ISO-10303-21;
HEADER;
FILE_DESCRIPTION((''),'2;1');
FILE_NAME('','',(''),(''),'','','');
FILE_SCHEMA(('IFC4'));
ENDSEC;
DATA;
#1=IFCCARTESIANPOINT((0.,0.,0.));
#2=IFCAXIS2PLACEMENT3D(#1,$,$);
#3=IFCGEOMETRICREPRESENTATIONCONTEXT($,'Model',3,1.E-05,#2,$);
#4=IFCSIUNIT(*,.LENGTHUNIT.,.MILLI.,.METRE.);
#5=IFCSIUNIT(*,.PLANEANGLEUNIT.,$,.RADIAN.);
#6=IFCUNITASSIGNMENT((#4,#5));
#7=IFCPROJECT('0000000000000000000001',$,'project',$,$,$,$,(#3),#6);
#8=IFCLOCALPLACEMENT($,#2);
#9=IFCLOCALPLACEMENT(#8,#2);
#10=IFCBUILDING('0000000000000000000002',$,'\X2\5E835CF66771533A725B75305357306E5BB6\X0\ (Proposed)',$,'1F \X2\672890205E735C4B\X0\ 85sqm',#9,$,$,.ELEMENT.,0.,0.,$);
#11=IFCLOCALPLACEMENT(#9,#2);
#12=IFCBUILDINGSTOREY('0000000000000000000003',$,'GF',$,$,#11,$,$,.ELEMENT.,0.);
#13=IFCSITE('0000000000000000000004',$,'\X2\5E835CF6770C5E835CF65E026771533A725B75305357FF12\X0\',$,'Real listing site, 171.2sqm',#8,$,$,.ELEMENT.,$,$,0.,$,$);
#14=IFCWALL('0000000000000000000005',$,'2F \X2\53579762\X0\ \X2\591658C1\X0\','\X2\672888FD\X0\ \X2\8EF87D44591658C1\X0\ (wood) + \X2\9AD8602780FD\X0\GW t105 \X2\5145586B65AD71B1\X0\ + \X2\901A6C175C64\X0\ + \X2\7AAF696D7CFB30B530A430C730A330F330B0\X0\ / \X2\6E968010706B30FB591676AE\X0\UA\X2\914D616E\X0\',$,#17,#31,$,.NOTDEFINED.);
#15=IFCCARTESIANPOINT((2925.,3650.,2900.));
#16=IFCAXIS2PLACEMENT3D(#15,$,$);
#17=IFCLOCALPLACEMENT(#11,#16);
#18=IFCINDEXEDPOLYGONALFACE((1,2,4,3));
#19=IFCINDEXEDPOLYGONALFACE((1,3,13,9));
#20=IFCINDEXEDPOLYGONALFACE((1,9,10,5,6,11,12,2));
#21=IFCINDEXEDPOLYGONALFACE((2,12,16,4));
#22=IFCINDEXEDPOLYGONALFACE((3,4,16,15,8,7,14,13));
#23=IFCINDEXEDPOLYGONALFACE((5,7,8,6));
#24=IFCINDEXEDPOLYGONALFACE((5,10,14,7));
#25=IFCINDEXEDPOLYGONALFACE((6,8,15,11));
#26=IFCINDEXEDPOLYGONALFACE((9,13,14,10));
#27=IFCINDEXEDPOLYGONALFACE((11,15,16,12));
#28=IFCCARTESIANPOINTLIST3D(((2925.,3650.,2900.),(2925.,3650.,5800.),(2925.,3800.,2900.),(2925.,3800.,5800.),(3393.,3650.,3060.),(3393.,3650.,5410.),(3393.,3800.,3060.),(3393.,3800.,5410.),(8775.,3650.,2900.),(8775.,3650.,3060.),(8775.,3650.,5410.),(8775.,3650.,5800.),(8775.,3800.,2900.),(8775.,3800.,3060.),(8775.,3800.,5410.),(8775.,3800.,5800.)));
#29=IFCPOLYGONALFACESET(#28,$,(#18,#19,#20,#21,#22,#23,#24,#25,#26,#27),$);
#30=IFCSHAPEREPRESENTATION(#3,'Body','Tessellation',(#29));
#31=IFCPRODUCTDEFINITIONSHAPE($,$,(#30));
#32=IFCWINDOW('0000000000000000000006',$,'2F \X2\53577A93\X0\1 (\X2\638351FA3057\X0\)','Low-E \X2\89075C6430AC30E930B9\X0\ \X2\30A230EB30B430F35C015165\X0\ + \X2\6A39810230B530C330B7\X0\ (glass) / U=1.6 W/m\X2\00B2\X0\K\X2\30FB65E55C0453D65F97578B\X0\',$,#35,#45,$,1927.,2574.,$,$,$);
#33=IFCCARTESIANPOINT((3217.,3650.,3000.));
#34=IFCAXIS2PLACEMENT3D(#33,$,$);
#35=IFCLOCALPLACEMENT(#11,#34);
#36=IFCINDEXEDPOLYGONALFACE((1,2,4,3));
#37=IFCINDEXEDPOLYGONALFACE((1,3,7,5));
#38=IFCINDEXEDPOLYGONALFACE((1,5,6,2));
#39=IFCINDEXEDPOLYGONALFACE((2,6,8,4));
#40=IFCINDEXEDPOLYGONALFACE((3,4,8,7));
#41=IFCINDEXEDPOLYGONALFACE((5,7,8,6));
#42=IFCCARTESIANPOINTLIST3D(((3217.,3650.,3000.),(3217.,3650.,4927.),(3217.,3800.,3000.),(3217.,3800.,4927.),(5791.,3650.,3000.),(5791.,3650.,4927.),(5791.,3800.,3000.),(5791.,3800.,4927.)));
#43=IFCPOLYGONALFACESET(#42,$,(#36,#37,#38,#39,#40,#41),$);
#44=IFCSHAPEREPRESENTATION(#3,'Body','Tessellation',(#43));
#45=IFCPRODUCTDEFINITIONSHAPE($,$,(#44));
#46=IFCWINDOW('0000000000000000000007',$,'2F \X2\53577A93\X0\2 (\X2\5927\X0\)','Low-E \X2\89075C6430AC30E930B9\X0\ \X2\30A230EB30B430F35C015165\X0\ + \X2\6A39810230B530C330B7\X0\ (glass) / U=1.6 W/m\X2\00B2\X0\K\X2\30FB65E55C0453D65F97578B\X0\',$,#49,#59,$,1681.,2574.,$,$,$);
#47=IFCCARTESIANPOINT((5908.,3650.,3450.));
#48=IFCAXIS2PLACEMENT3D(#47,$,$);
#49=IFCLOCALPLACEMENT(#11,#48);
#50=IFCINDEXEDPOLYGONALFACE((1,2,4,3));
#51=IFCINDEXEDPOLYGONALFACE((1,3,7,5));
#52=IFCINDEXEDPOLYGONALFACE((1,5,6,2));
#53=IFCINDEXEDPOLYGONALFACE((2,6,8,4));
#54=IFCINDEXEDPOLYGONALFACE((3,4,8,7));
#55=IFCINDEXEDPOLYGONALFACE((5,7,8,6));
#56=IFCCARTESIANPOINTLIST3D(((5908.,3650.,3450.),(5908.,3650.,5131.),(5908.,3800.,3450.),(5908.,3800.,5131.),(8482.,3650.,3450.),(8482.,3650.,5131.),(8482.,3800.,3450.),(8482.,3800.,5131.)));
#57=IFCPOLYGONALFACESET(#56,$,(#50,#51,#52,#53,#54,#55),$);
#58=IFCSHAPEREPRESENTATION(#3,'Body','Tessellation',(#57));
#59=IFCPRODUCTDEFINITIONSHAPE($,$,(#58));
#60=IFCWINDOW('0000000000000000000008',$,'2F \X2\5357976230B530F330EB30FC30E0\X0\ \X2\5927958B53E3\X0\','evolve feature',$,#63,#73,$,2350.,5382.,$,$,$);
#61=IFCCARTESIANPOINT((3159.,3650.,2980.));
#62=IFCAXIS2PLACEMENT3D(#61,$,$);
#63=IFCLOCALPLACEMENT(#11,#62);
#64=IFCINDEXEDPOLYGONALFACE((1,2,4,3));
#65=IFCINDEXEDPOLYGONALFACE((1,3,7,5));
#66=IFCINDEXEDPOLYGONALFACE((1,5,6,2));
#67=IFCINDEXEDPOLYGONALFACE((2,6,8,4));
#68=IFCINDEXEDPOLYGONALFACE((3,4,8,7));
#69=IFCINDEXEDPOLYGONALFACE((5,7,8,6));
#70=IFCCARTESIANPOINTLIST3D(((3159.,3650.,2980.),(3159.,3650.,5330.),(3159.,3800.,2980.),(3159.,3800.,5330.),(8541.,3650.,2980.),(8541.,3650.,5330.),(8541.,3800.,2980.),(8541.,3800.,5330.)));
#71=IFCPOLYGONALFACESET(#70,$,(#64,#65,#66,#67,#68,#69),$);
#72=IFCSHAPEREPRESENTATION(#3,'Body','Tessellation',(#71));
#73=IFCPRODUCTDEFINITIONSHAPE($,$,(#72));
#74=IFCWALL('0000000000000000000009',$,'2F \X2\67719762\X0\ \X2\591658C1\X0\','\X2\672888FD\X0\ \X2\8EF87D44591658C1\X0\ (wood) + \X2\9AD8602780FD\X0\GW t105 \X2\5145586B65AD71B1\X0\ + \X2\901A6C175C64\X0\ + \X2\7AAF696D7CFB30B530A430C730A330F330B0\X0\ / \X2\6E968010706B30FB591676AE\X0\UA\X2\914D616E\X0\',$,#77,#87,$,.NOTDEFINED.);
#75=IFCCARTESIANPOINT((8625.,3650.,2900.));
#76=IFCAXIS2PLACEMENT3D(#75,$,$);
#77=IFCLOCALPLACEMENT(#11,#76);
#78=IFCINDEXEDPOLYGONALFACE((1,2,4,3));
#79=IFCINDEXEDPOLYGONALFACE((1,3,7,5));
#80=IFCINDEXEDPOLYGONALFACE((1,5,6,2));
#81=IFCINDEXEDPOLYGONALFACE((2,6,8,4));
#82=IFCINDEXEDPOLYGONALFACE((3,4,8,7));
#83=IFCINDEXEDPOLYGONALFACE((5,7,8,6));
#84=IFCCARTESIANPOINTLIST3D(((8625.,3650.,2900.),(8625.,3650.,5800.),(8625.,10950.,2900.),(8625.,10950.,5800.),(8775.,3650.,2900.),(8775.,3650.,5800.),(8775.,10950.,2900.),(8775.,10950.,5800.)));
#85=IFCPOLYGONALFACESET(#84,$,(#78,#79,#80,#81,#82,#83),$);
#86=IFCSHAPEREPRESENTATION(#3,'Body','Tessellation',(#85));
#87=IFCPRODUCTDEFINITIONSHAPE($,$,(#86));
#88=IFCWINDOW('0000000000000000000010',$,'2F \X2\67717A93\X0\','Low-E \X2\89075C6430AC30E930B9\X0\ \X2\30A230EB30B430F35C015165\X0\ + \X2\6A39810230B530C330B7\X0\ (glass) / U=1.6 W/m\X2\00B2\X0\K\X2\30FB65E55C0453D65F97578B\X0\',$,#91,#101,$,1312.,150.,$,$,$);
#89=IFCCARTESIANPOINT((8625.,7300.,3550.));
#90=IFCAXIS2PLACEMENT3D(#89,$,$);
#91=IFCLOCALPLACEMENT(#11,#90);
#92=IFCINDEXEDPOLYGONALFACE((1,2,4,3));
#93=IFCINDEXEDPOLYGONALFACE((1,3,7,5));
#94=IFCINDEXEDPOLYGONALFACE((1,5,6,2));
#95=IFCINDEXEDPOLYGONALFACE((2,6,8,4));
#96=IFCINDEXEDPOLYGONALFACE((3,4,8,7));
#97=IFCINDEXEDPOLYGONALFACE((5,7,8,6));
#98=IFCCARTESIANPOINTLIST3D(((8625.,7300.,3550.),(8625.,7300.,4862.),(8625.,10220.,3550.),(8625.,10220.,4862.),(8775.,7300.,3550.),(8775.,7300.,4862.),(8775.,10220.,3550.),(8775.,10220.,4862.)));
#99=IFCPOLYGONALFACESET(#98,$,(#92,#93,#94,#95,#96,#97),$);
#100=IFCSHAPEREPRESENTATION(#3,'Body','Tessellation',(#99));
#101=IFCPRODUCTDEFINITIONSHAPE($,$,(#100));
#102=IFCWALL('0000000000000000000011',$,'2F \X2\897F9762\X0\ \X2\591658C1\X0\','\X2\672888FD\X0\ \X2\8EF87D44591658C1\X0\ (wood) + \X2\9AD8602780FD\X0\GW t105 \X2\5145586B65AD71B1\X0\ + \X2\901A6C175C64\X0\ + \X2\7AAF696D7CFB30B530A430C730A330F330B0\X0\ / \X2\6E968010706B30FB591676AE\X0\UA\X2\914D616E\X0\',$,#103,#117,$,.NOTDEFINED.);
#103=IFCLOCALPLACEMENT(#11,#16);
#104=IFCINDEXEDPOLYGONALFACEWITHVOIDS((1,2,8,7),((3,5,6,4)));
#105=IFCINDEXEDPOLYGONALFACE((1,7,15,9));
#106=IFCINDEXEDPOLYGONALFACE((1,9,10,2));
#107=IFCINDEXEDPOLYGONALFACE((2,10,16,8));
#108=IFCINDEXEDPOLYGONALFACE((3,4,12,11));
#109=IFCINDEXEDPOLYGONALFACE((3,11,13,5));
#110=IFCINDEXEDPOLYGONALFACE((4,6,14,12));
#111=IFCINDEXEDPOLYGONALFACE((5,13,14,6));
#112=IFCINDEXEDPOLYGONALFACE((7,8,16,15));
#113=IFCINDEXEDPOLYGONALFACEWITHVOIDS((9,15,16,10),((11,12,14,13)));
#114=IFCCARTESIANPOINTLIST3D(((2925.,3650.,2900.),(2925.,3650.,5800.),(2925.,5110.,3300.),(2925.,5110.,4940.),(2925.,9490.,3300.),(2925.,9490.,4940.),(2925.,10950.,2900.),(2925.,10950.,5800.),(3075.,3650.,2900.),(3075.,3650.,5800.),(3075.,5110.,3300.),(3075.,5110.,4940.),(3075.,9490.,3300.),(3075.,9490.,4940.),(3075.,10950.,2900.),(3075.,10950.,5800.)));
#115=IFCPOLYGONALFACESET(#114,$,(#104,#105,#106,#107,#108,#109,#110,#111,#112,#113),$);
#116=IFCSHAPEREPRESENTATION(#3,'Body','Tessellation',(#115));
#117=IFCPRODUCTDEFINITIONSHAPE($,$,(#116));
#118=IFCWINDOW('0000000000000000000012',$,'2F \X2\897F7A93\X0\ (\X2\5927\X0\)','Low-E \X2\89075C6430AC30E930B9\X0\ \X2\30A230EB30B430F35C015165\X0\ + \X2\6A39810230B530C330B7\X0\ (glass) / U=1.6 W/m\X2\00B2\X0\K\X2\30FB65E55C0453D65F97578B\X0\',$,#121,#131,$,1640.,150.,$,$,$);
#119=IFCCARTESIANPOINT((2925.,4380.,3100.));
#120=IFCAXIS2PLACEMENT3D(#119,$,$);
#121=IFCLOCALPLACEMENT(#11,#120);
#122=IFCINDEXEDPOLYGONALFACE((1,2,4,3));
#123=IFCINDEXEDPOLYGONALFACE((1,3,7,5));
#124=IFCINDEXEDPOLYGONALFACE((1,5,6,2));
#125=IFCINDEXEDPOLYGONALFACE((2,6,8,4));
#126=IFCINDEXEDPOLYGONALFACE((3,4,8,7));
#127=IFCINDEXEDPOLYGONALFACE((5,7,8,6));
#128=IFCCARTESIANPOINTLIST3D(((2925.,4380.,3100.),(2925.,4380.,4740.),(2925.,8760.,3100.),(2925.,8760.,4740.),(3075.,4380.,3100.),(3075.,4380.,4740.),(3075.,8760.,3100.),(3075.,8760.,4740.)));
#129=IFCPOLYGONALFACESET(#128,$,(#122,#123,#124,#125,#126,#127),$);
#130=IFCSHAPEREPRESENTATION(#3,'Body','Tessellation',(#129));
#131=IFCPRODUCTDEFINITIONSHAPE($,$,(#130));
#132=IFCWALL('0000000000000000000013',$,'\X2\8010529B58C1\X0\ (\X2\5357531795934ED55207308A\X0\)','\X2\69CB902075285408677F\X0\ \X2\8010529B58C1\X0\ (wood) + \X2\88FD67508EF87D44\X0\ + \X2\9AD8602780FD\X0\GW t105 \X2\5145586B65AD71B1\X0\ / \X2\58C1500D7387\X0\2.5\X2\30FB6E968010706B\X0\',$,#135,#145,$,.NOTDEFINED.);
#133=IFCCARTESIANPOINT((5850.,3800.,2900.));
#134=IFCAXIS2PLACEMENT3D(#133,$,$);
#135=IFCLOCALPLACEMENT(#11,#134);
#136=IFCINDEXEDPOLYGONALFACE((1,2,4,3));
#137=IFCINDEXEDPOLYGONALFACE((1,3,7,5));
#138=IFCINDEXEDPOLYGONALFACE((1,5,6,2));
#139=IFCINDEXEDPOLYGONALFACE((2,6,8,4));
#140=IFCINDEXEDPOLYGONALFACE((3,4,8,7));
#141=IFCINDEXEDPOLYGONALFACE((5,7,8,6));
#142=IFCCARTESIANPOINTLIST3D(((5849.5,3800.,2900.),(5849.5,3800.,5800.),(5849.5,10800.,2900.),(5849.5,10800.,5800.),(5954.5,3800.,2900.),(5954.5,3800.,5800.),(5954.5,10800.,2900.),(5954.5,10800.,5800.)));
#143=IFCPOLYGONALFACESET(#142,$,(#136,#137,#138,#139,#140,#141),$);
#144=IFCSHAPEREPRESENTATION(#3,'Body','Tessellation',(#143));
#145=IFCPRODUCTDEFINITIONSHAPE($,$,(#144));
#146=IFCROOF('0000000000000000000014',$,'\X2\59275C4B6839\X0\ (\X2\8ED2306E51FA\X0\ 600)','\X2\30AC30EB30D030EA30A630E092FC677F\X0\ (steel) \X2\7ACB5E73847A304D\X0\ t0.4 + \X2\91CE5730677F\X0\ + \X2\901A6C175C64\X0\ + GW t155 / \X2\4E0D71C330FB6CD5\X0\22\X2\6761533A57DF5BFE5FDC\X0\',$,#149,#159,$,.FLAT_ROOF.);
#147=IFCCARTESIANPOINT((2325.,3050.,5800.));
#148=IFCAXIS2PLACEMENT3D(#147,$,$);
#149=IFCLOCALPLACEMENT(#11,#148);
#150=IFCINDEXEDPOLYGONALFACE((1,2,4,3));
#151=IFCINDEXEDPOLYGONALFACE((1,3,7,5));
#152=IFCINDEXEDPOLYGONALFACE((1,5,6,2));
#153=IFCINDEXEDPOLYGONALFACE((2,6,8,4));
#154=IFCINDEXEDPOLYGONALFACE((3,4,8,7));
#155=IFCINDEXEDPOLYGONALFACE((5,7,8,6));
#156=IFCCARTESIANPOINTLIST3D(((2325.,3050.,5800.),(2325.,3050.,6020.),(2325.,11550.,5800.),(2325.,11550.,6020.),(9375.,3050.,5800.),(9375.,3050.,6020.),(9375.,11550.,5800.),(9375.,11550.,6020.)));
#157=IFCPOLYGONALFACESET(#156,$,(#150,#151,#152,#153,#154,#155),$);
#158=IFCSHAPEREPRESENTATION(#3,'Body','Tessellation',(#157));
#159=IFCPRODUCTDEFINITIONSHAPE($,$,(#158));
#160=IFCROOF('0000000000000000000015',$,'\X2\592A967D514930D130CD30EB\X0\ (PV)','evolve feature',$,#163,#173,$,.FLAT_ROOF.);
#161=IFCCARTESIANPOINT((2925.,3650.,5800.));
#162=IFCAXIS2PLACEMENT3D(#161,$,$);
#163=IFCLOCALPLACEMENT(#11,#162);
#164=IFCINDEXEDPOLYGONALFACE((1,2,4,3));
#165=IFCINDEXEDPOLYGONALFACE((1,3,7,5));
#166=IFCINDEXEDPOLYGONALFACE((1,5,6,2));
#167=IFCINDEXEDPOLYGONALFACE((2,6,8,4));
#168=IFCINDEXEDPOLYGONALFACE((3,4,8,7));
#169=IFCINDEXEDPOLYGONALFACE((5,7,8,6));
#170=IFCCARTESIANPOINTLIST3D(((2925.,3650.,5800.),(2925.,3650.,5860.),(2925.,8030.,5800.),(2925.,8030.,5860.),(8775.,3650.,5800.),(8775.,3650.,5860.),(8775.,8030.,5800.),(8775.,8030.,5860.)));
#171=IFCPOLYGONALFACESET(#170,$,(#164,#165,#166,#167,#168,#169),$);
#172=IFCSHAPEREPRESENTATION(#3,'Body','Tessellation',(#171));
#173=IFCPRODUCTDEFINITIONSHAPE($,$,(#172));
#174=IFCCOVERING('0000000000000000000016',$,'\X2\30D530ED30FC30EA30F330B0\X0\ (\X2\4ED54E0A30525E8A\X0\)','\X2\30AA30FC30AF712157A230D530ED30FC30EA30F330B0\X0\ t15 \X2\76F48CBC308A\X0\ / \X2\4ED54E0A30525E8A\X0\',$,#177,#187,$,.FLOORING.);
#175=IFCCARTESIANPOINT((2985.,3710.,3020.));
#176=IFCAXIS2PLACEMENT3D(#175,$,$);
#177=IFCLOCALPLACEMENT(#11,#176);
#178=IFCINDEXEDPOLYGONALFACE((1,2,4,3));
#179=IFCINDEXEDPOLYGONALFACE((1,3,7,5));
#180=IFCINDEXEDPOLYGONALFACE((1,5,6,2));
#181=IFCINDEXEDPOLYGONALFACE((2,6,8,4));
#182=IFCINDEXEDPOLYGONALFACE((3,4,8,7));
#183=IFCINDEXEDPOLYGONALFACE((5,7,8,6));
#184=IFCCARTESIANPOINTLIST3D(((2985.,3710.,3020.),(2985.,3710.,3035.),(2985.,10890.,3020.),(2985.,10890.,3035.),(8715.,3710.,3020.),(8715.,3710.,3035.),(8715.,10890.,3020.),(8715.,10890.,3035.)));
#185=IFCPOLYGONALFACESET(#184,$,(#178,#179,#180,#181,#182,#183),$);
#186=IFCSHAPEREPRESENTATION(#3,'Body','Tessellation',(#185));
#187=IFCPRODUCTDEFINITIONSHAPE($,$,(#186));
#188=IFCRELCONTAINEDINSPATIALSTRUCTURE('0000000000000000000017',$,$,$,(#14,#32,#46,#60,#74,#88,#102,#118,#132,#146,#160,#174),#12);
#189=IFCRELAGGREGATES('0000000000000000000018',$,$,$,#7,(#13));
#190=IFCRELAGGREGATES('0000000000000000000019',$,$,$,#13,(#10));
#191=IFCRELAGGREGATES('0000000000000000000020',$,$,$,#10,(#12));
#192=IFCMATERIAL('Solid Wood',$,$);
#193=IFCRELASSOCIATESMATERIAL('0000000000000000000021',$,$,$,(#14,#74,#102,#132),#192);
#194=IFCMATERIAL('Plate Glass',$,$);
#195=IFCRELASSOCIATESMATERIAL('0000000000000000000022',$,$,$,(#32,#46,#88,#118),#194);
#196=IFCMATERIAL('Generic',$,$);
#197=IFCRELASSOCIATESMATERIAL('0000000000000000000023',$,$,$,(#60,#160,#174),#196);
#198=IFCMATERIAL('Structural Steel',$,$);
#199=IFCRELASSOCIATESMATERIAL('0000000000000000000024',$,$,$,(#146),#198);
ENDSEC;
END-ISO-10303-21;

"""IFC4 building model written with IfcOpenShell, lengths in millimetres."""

from ifc_helpers import new_model, si_unit, frame, frame_2d, origin, place, context, project, spatial, rectangle, extrude, material, element, fill, save


model = new_model("IFC4")

# Units and contexts
model_context = context("Model", 3, precision=1e-05, world=origin())
ifc_project = project(units=[si_unit("LENGTHUNIT", "METRE", prefix="MILLI"), si_unit("PLANEANGLEUNIT", "RADIAN")], contexts=[model_context])

# Site, building, storey
site_placement = place(None, origin())
site = spatial("IfcSite", under=ifc_project, at=site_placement, Name="広島県広島市東区牛田南２", ObjectType="Real listing site, 171.2sqm", CompositionType="ELEMENT", RefElevation=0.0)
building_placement = place(site_placement, origin())
building = spatial("IfcBuilding", under=site, at=building_placement, Name="広島東区牛田南の家 (Proposed)", ObjectType="1F 木造平屋 85sqm", CompositionType="ELEMENT", ElevationOfRefHeight=0.0, ElevationOfTerrain=0.0)
storey_placement = place(building_placement, origin())
storey = spatial("IfcBuildingStorey", under=building, at=storey_placement, Name="GF", CompositionType="ELEMENT", Elevation=0.0)

# Shared definitions
ifc_material_1 = material(Name="Solid Wood")

# Wall, openings, windows
wall_1_placement = place(storey_placement, frame((2925.0, 3650.0, 2900.0)))
wall_1 = element("IfcWall", 1, at=wall_1_placement, inside=storey, material=ifc_material_1, Name="2F 南面 外壁", Description="木製 軸組外壁 (wood) + 高性能GW t105 充填断熱 + 通気層 + 窯業系サイディング / 準耐火・外皮UA配慮", PredefinedType="NOTDEFINED", context=model_context, shape_type="SweptSolid", body=[
    extrude(rectangle(XDim=5850.0, YDim=150.0, at=frame_2d((2925.0, 75.0))), frame((2925.0, 3650.0, 2900.0)), (0.0, 0.0, 1.0), 2900.0),
])
opening_1_placement = place(storey_placement, frame((3217.0, 3650.0, 3000.0)))
opening_1 = element("IfcOpeningElement", 2, at=opening_1_placement, cuts=wall_1, PredefinedType="NOTDEFINED", context=model_context, shape_type="SweptSolid", body=[
    extrude(rectangle(XDim=2574.0, YDim=150.0, at=frame_2d((1287.0, 75.0))), frame((3217.0, 3650.0, 3000.0)), (0.0, 0.0, 1.0), 1927.0),
])
opening_2_placement = place(storey_placement, frame((5908.0, 3650.0, 3450.0)))
opening_2 = element("IfcOpeningElement", 3, at=opening_2_placement, cuts=wall_1, PredefinedType="NOTDEFINED", context=model_context, shape_type="SweptSolid", body=[
    extrude(rectangle(XDim=2574.0, YDim=150.0, at=frame_2d((1287.0, 75.0))), frame((5908.0, 3650.0, 3450.0)), (0.0, 0.0, 1.0), 1681.0),
])
opening_3_placement = place(storey_placement, frame((3159.0, 3650.0, 2980.0)))
opening_3 = element("IfcOpeningElement", 4, at=opening_3_placement, cuts=wall_1, PredefinedType="NOTDEFINED", context=model_context, shape_type="SweptSolid", body=[
    extrude(rectangle(XDim=5382.0, YDim=150.0, at=frame_2d((2691.0, 75.0))), frame((3159.0, 3650.0, 2980.0)), (0.0, 0.0, 1.0), 2350.0),
])
ifc_material_2 = material(Name="Plate Glass")
window_1_placement = place(storey_placement, frame((3217.0, 3650.0, 3000.0)))
window_1 = element("IfcWindow", 5, at=window_1_placement, inside=storey, material=ifc_material_2, Name="2F 南窓1 (掃出し)", Description="Low-E 複層ガラス アルゴン封入 + 樹脂サッシ (glass) / U=1.6 W/m²K・日射取得型", OverallHeight=1927.0, OverallWidth=2574.0, context=model_context, shape_type="SweptSolid", body=[
    extrude(rectangle(XDim=2574.0, YDim=150.0, at=frame_2d((1287.0, 75.0))), frame((3217.0, 3650.0, 3000.0)), (0.0, 0.0, 1.0), 1927.0),
])
fill(opening_1, window_1)
window_2_placement = place(storey_placement, frame((5908.0, 3650.0, 3450.0)))
window_2 = element("IfcWindow", 6, at=window_2_placement, inside=storey, material=ifc_material_2, Name="2F 南窓2 (大)", Description="Low-E 複層ガラス アルゴン封入 + 樹脂サッシ (glass) / U=1.6 W/m²K・日射取得型", OverallHeight=1681.0, OverallWidth=2574.0, context=model_context, shape_type="SweptSolid", body=[
    extrude(rectangle(XDim=2574.0, YDim=150.0, at=frame_2d((1287.0, 75.0))), frame((5908.0, 3650.0, 3450.0)), (0.0, 0.0, 1.0), 1681.0),
])
fill(opening_2, window_2)
ifc_material_3 = material(Name="Generic")
window_3_placement = place(storey_placement, frame((3159.0, 3650.0, 2980.0)))
window_3 = element("IfcWindow", 7, at=window_3_placement, inside=storey, material=ifc_material_3, Name="2F 南面サンルーム 大開口", Description="evolve feature", OverallHeight=2350.0, OverallWidth=5382.0, context=model_context, shape_type="SweptSolid", body=[
    extrude(rectangle(XDim=5382.0, YDim=150.0, at=frame_2d((2691.0, 75.0))), frame((3159.0, 3650.0, 2980.0)), (0.0, 0.0, 1.0), 2350.0),
])
fill(opening_3, window_3)

# Walls, openings, windows
wall_2_placement = place(storey_placement, frame((8625.0, 3650.0, 2900.0)))
wall_2 = element("IfcWall", 8, at=wall_2_placement, inside=storey, material=ifc_material_1, Name="2F 東面 外壁", Description="木製 軸組外壁 (wood) + 高性能GW t105 充填断熱 + 通気層 + 窯業系サイディング / 準耐火・外皮UA配慮", PredefinedType="NOTDEFINED", context=model_context, shape_type="SweptSolid", body=[
    extrude(rectangle(XDim=150.0, YDim=7300.0, at=frame_2d((75.0, 3650.0))), frame((8625.0, 3650.0, 2900.0)), (0.0, 0.0, 1.0), 2900.0),
])
opening_4_placement = place(storey_placement, frame((8625.0, 7300.0, 3550.0)))
opening_4 = element("IfcOpeningElement", 9, at=opening_4_placement, cuts=wall_2, PredefinedType="NOTDEFINED", context=model_context, shape_type="SweptSolid", body=[
    extrude(rectangle(XDim=150.0, YDim=2920.0, at=frame_2d((75.0, 1460.0))), frame((8625.0, 7300.0, 3550.0)), (0.0, 0.0, 1.0), 1312.0),
])
window_4_placement = place(storey_placement, frame((8625.0, 7300.0, 3550.0)))
window_4 = element("IfcWindow", 10, at=window_4_placement, inside=storey, material=ifc_material_2, Name="2F 東窓", Description="Low-E 複層ガラス アルゴン封入 + 樹脂サッシ (glass) / U=1.6 W/m²K・日射取得型", OverallHeight=1312.0, OverallWidth=150.0, context=model_context, shape_type="SweptSolid", body=[
    extrude(rectangle(XDim=150.0, YDim=2920.0, at=frame_2d((75.0, 1460.0))), frame((8625.0, 7300.0, 3550.0)), (0.0, 0.0, 1.0), 1312.0),
])
fill(opening_4, window_4)
wall_3_placement = place(storey_placement, frame((2925.0, 3650.0, 2900.0)))
wall_3 = element("IfcWall", 11, at=wall_3_placement, inside=storey, material=ifc_material_1, Name="2F 西面 外壁", Description="木製 軸組外壁 (wood) + 高性能GW t105 充填断熱 + 通気層 + 窯業系サイディング / 準耐火・外皮UA配慮", PredefinedType="NOTDEFINED", context=model_context, shape_type="SweptSolid", body=[
    extrude(rectangle(XDim=150.0, YDim=7300.0, at=frame_2d((75.0, 3650.0))), frame((2925.0, 3650.0, 2900.0)), (0.0, 0.0, 1.0), 2900.0),
])
opening_5_placement = place(storey_placement, frame((2925.0, 4380.0, 3100.0)))
opening_5 = element("IfcOpeningElement", 12, at=opening_5_placement, cuts=wall_3, PredefinedType="NOTDEFINED", context=model_context, shape_type="SweptSolid", body=[
    extrude(rectangle(XDim=150.0, YDim=4380.0, at=frame_2d((75.0, 2190.0))), frame((2925.0, 4380.0, 3100.0)), (0.0, 0.0, 1.0), 1640.0),
])
window_5_placement = place(storey_placement, frame((2925.0, 4380.0, 3100.0)))
window_5 = element("IfcWindow", 13, at=window_5_placement, inside=storey, material=ifc_material_2, Name="2F 西窓 (大)", Description="Low-E 複層ガラス アルゴン封入 + 樹脂サッシ (glass) / U=1.6 W/m²K・日射取得型", OverallHeight=1640.0, OverallWidth=150.0, context=model_context, shape_type="SweptSolid", body=[
    extrude(rectangle(XDim=150.0, YDim=4380.0, at=frame_2d((75.0, 2190.0))), frame((2925.0, 4380.0, 3100.0)), (0.0, 0.0, 1.0), 1640.0),
])
fill(opening_5, window_5)

# Wall
wall_4_placement = place(storey_placement, frame((5850.0, 3800.0, 2900.0)))
element("IfcWall", 14, at=wall_4_placement, inside=storey, material=ifc_material_1, Name="耐力壁 (南北間仕切り)", Description="構造用合板 耐力壁 (wood) + 製材軸組 + 高性能GW t105 充填断熱 / 壁倍率2.5・準耐火", PredefinedType="NOTDEFINED", context=model_context, shape_type="SweptSolid", body=[
    extrude(rectangle(XDim=105.0, YDim=7000.0, at=frame_2d((52.0, 3500.0))), frame((5850.0, 3800.0, 2900.0)), (0.0, 0.0, 1.0), 2900.0),
])

# Roofs
ifc_material_4 = material(Name="Structural Steel")
roof_1_placement = place(storey_placement, frame((2325.0, 3050.0, 5800.0)))
element("IfcRoof", 15, at=roof_1_placement, inside=storey, material=ifc_material_4, Name="大屋根 (軒の出 600)", Description="ガルバリウム鋼板 (steel) 立平葺き t0.4 + 野地板 + 通気層 + GW t155 / 不燃・法22条区域対応", PredefinedType="FLAT_ROOF", context=model_context, shape_type="SweptSolid", body=[
    extrude(rectangle(XDim=7050.0, YDim=8500.0, at=frame_2d((3525.0, 4250.0))), frame((2325.0, 3050.0, 5800.0)), (0.0, 0.0, 1.0), 220.0),
])
roof_2_placement = place(storey_placement, frame((2925.0, 3650.0, 5800.0)))
element("IfcRoof", 16, at=roof_2_placement, inside=storey, material=ifc_material_3, Name="太陽光パネル (PV)", Description="evolve feature", PredefinedType="FLAT_ROOF", context=model_context, shape_type="SweptSolid", body=[
    extrude(rectangle(XDim=5850.0, YDim=4380.0, at=frame_2d((2925.0, 2190.0))), frame((2925.0, 3650.0, 5800.0)), (0.0, 0.0, 1.0), 60.0),
])

# Covering
covering_placement = place(storey_placement, frame((2985.0, 3710.0, 3020.0)))
element("IfcCovering", 17, at=covering_placement, inside=storey, material=ifc_material_3, Name="フローリング (仕上げ床)", Description="オーク無垢フローリング t15 直貼り / 仕上げ床", PredefinedType="FLOORING", context=model_context, shape_type="SweptSolid", body=[
    extrude(rectangle(XDim=5730.0, YDim=7180.0, at=frame_2d((2865.0, 3590.0))), frame((2985.0, 3710.0, 3020.0)), (0.0, 0.0, 1.0), 15.0),
])

save(model, "model.ifc")
